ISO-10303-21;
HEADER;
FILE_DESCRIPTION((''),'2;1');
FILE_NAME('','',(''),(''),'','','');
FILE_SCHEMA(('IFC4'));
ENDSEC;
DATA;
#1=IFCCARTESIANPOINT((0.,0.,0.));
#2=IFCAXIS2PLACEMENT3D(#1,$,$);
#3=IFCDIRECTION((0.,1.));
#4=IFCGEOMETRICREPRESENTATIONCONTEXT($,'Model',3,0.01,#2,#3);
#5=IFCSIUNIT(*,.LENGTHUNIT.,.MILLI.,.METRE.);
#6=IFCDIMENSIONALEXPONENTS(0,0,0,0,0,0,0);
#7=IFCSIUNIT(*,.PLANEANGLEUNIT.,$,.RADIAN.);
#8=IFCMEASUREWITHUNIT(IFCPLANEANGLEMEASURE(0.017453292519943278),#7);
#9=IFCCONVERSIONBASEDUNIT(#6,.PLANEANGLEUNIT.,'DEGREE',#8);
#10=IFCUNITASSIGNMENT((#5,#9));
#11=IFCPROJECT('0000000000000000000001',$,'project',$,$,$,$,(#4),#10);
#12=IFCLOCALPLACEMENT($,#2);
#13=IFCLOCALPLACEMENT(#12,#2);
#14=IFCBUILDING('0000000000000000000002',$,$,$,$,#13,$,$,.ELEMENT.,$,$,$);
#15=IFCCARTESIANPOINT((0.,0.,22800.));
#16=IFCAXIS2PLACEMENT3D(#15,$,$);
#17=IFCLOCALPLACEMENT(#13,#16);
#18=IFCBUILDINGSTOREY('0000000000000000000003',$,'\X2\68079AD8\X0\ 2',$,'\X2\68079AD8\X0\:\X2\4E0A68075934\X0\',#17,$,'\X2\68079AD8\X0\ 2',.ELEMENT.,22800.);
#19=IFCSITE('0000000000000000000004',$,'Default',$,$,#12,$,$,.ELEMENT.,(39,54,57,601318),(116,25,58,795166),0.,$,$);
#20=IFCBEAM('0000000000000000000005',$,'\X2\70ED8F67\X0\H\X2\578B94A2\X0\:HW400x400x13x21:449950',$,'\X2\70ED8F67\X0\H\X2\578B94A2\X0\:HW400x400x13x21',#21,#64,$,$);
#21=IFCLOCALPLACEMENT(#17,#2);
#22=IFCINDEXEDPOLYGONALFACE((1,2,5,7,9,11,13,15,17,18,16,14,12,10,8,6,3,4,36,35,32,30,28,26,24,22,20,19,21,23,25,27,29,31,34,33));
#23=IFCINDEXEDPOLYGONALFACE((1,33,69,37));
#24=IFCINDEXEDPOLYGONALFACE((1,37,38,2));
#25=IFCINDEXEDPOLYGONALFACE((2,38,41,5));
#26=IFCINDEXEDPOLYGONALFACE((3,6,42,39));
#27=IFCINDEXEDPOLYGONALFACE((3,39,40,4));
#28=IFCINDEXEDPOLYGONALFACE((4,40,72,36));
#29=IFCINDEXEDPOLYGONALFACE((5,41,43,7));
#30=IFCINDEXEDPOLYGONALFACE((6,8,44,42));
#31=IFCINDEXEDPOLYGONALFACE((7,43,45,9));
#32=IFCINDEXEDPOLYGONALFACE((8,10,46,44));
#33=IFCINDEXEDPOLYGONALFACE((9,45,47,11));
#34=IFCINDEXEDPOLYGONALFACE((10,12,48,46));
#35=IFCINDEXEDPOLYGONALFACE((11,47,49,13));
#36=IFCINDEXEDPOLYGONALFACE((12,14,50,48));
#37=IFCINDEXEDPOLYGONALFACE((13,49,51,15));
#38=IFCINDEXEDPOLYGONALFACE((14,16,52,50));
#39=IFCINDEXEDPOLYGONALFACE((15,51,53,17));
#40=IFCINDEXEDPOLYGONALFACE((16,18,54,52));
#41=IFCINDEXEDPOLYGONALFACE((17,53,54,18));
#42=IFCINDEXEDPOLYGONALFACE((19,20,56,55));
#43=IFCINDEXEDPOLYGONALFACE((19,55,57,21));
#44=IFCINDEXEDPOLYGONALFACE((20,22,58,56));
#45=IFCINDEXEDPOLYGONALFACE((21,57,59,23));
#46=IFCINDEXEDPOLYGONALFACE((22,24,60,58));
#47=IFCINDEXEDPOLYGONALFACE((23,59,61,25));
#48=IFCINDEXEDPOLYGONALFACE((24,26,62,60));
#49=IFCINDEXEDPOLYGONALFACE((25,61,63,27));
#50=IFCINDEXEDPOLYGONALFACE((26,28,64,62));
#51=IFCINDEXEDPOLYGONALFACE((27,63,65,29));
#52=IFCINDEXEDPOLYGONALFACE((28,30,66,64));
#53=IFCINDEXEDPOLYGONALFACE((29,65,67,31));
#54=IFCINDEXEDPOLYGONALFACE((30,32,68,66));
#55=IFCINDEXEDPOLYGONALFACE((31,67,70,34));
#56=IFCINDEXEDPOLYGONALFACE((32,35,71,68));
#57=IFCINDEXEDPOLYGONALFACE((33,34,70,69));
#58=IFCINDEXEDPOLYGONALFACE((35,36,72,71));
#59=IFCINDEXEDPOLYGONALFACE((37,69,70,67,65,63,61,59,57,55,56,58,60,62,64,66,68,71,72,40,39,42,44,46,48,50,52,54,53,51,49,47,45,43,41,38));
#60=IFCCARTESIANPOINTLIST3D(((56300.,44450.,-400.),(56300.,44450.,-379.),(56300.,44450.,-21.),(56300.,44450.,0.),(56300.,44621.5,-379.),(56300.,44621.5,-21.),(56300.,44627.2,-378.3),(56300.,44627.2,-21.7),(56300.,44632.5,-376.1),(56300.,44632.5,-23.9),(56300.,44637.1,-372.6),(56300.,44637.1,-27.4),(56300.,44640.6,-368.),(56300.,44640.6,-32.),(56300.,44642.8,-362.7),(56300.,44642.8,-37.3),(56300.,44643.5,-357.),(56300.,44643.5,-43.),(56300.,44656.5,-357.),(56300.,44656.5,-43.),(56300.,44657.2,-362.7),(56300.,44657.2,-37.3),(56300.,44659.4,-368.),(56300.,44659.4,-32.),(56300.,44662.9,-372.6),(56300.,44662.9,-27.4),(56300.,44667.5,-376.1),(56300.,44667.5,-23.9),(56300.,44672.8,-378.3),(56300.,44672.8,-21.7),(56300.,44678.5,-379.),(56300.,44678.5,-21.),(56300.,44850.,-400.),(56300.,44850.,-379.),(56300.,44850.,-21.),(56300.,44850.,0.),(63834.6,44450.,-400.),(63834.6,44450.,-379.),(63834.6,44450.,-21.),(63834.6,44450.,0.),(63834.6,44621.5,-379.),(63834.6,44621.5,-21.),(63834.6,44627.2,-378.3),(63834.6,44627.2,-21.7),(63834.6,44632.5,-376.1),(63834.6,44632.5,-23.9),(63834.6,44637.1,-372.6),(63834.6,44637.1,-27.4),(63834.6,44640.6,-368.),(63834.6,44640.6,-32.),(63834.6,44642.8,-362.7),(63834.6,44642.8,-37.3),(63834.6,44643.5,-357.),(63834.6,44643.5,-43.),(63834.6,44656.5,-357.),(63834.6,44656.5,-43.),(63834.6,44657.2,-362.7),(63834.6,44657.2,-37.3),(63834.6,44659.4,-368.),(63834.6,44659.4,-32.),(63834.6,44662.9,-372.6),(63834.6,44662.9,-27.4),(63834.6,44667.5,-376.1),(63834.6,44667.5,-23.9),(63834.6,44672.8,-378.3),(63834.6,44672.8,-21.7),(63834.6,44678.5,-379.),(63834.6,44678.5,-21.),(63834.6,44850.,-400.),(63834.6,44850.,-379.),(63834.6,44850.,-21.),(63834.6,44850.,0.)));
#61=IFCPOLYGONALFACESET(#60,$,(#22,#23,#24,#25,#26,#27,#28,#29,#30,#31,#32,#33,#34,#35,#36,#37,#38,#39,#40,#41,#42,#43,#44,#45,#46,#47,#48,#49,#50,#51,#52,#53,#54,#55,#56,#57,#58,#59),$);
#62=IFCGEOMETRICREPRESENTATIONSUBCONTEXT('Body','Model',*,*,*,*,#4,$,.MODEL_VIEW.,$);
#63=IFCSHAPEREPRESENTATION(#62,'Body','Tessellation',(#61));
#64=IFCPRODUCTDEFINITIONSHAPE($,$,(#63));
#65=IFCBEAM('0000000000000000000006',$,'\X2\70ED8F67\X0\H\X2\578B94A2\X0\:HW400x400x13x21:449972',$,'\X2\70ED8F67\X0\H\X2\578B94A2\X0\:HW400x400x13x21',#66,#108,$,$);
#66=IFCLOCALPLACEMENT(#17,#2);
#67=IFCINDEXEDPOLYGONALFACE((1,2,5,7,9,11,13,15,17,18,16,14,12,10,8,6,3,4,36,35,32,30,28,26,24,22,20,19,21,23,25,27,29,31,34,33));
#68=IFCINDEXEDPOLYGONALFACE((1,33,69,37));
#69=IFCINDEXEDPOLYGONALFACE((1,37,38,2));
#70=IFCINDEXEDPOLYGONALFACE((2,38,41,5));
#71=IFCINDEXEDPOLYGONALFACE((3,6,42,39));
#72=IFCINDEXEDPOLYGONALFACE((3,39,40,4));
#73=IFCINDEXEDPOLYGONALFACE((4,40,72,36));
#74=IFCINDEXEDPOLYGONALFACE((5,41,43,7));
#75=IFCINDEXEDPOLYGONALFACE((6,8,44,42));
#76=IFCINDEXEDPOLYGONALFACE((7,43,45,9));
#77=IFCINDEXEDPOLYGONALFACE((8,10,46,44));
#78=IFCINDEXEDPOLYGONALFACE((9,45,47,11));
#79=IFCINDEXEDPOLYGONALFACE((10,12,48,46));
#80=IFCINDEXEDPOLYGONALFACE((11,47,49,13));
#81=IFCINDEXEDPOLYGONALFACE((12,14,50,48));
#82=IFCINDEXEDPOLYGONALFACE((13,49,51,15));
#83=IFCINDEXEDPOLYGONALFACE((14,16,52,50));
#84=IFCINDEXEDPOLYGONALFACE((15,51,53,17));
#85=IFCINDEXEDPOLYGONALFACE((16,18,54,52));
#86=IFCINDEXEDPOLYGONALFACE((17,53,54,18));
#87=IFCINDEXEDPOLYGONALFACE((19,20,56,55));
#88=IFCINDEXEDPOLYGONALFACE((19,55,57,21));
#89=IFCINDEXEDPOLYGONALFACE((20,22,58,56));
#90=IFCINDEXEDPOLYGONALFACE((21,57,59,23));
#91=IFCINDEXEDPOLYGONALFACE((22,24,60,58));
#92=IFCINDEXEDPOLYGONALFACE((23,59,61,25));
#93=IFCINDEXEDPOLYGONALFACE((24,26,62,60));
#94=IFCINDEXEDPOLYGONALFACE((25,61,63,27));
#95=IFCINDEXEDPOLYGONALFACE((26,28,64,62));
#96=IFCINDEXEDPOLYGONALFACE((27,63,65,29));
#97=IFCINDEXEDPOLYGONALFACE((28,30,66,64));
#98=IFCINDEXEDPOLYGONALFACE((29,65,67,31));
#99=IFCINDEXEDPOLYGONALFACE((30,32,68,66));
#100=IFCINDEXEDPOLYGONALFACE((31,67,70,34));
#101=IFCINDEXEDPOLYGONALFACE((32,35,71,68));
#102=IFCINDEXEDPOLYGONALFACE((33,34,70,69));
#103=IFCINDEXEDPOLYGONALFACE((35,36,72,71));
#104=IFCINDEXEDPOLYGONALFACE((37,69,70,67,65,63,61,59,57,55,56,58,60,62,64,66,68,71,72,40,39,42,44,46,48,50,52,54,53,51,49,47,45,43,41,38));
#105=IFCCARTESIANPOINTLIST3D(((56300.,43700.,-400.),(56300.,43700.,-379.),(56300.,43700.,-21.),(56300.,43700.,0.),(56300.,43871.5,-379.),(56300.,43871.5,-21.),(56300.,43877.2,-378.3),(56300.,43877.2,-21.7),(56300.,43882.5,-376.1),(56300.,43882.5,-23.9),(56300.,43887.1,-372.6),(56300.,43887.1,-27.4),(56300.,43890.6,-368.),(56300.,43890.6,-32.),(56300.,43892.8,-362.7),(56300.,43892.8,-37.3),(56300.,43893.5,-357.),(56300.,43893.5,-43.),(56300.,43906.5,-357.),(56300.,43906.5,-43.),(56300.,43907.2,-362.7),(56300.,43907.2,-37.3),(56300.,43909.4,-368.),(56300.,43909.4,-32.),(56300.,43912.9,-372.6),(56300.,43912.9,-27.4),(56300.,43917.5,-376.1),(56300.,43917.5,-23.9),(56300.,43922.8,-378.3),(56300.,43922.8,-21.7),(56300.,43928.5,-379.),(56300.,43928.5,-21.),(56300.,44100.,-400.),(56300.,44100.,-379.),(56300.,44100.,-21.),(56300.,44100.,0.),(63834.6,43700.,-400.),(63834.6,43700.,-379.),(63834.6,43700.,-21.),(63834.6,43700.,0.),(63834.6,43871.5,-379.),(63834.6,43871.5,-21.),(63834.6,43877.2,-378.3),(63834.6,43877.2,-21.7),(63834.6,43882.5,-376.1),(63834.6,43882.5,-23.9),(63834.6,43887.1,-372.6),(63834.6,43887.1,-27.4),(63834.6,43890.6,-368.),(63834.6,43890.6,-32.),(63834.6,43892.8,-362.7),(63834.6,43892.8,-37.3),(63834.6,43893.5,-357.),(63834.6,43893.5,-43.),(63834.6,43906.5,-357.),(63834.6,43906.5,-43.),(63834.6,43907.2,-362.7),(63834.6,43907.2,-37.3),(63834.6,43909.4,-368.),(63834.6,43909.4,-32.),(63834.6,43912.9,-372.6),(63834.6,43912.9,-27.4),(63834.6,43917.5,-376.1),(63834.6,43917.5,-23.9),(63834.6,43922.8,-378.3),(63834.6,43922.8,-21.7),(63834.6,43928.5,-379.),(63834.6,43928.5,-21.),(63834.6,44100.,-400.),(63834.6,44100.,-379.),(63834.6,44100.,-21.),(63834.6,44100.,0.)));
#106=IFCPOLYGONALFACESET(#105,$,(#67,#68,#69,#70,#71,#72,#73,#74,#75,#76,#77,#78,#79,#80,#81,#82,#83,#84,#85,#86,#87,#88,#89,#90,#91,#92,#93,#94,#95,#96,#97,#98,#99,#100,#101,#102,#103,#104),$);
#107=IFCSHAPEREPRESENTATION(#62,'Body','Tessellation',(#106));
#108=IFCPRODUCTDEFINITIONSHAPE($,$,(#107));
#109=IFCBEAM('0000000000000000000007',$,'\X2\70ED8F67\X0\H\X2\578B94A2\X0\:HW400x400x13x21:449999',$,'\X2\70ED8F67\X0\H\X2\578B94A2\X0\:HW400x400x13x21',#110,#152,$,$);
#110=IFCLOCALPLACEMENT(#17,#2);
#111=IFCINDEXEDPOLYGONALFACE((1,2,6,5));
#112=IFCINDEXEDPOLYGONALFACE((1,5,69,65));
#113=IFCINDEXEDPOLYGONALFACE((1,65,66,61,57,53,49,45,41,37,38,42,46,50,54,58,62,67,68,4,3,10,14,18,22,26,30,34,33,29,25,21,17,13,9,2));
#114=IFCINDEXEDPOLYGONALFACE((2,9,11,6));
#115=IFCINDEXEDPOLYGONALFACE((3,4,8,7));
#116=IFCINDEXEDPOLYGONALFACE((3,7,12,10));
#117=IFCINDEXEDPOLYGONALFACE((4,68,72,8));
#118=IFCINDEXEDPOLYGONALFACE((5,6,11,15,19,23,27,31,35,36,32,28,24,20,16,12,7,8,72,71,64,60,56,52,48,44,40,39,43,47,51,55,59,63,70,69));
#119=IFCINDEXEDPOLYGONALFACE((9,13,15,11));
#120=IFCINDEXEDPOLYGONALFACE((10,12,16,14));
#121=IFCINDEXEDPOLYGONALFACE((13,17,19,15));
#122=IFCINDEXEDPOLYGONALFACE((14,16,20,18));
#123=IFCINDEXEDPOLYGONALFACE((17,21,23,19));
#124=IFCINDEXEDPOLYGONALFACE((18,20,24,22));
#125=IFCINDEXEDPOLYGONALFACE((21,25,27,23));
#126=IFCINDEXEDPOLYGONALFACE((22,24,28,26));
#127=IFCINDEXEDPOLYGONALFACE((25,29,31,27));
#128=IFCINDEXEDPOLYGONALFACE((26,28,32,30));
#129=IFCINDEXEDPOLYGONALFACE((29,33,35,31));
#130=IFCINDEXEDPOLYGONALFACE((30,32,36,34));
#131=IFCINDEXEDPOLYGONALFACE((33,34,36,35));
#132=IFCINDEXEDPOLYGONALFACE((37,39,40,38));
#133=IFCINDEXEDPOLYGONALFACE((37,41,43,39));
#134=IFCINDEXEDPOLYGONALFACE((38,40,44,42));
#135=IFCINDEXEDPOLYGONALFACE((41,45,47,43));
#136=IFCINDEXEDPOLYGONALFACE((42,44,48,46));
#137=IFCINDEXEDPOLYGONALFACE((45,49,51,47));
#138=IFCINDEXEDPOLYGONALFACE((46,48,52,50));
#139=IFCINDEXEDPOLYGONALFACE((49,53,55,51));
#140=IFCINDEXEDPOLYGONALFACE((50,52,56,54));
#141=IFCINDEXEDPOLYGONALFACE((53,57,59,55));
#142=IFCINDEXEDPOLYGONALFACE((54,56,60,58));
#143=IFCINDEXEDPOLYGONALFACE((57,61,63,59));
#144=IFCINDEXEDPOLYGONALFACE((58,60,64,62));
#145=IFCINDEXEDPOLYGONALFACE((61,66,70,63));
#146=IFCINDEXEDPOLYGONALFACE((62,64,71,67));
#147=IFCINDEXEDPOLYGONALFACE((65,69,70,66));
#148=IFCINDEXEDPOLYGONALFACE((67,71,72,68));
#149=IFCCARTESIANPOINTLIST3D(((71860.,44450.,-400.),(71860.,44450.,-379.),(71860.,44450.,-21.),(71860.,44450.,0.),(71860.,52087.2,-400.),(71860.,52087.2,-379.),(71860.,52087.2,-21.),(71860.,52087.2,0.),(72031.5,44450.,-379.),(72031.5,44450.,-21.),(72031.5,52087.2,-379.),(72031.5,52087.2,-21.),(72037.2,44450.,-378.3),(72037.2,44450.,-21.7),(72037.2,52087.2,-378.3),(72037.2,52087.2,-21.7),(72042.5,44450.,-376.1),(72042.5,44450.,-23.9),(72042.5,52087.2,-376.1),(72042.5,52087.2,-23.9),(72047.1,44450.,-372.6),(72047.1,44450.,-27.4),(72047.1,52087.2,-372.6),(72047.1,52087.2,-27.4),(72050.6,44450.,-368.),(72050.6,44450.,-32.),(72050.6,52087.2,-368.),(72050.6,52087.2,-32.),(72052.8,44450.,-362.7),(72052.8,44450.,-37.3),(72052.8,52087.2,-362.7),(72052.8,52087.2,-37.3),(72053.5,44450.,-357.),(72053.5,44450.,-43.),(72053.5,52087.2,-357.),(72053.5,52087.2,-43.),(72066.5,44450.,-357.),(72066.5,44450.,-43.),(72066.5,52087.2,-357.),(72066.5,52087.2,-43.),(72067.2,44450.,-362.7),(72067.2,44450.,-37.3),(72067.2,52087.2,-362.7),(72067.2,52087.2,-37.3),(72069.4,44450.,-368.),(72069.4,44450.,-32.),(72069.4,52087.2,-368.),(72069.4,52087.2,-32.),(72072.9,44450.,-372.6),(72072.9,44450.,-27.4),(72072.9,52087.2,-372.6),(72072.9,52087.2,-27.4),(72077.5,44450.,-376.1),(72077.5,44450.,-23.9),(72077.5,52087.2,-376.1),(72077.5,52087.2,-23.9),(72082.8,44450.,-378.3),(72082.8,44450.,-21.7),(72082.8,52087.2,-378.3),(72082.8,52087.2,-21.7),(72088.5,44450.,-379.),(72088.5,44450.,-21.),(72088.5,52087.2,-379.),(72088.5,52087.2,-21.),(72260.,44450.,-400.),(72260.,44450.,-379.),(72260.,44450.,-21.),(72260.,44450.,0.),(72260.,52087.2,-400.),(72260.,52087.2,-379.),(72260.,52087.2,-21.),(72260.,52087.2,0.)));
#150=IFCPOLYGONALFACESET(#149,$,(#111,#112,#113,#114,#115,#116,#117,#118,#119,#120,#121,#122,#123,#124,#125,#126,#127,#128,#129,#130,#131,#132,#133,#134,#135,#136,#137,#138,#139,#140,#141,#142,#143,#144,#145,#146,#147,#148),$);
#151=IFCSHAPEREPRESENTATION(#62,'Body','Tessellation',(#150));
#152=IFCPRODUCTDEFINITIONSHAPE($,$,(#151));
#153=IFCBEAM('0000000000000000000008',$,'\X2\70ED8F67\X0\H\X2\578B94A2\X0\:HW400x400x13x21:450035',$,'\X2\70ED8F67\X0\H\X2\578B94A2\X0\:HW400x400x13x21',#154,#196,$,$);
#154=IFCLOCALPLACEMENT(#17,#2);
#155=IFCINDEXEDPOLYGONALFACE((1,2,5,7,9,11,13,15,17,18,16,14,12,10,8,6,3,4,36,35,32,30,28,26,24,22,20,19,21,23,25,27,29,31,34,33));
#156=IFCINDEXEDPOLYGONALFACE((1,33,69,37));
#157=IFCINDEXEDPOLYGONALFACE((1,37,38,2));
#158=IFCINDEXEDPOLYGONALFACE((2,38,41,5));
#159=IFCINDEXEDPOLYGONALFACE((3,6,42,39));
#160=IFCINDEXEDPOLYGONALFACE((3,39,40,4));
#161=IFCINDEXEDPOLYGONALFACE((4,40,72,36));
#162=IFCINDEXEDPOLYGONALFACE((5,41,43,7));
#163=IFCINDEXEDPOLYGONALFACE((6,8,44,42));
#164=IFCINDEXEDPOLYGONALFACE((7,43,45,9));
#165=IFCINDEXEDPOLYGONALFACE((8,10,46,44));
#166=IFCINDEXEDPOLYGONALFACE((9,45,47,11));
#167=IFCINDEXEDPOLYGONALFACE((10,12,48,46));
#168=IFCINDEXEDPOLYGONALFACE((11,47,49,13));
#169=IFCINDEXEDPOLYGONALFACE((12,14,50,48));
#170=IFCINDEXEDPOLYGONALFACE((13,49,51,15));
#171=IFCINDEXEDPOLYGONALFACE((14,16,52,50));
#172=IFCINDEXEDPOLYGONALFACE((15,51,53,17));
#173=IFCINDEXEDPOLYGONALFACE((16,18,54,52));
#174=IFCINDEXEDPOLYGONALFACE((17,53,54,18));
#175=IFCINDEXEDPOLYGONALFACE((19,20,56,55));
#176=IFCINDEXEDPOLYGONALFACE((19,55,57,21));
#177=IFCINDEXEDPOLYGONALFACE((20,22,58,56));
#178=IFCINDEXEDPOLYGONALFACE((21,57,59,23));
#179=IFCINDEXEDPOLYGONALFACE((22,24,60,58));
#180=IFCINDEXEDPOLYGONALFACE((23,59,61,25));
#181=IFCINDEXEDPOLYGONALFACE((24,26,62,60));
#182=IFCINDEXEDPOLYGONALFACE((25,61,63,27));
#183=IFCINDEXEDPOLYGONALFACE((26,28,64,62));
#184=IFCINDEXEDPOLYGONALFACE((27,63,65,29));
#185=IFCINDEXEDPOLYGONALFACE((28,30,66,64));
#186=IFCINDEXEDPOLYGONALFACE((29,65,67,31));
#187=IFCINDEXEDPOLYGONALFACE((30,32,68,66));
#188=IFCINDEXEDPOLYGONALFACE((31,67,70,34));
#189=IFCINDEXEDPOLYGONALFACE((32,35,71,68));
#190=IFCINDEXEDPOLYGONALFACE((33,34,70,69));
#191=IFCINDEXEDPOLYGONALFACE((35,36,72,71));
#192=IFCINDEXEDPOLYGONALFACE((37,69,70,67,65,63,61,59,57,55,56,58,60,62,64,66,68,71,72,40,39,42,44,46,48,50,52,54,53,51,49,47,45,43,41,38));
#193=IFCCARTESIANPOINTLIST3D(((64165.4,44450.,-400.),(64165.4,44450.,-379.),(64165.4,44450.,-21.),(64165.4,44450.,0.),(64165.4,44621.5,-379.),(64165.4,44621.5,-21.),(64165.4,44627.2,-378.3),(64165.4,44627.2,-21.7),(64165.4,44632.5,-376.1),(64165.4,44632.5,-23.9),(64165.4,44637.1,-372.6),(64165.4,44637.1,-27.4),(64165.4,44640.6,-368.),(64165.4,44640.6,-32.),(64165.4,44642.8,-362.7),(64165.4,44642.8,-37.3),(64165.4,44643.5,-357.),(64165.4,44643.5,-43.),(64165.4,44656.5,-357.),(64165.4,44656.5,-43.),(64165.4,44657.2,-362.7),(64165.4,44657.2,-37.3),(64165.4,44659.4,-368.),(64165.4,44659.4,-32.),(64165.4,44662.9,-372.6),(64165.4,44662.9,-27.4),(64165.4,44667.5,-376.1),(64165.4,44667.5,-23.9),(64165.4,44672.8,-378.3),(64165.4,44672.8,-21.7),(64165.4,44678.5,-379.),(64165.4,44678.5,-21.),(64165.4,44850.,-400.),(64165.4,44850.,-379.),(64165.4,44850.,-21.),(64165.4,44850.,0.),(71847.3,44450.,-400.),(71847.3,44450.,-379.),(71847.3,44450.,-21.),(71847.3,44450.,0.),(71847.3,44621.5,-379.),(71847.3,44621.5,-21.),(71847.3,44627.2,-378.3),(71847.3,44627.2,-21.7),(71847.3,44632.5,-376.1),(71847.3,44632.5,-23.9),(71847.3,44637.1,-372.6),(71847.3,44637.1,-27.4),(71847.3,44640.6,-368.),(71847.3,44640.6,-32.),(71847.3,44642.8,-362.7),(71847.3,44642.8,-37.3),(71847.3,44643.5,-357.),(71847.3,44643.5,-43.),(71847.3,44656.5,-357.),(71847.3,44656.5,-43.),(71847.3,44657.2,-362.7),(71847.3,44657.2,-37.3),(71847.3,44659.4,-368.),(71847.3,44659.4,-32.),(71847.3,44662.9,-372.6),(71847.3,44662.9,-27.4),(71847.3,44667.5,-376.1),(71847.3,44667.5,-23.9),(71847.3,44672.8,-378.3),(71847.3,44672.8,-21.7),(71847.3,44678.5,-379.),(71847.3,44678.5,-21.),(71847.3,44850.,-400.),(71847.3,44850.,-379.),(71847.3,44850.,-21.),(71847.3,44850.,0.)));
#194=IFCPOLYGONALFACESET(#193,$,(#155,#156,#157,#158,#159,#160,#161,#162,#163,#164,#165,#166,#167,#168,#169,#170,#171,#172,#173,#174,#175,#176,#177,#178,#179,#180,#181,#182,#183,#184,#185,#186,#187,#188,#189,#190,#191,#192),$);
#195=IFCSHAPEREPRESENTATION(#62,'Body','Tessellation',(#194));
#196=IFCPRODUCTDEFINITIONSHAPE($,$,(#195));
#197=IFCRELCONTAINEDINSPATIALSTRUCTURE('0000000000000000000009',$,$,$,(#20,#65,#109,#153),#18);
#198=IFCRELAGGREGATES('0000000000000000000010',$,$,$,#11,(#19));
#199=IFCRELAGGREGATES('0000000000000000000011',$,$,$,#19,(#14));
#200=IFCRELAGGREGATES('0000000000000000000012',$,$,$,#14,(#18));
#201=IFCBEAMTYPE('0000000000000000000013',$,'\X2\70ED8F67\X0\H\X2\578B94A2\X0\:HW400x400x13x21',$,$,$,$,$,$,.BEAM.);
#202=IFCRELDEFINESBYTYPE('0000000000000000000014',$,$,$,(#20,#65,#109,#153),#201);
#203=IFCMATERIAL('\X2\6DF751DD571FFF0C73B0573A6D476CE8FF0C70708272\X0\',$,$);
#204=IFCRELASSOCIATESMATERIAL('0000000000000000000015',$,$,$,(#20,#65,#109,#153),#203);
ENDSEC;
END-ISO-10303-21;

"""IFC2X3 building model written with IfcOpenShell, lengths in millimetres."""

from ifc_helpers import new_model, entity, si_unit, converted_unit, direction, frame, frame_2d, origin, place, context, subcontext, project, spatial, i_section, extrude, material, type_object, element, save


model = new_model("IFC2X3")

# Units and contexts
model_context = context("Model", 3, precision=0.01, world=origin(), true_north=direction((0.0, 1.0)))
body_context = subcontext(model_context, "Body", "Model", "MODEL_VIEW")
ifc_project = project(units=[si_unit("LENGTHUNIT", "METRE", prefix="MILLI"), converted_unit("PLANEANGLEUNIT", "DEGREE", entity("IfcPlaneAngleMeasure", 0.017453292519943278), si_unit("PLANEANGLEUNIT", "RADIAN"), dimensions=[0, 0, 0, 0, 0, 0, 0])], contexts=[model_context])

# Site, building, storey
site_placement = place(None, origin())
site = spatial("IfcSite", under=ifc_project, at=site_placement, Name="Default", CompositionType="ELEMENT", RefLatitude=(39, 54, 57, 601318), RefLongitude=(116, 25, 58, 795166), RefElevation=0.0)
building_placement = place(site_placement, origin())
building = spatial("IfcBuilding", under=site, at=building_placement, CompositionType="ELEMENT")
storey_placement = place(building_placement, frame((0.0, 0.0, 22800.0)))
storey = spatial("IfcBuildingStorey", under=building, at=storey_placement, Name="标高 2", ObjectType="标高:上标头", LongName="标高 2", CompositionType="ELEMENT", Elevation=22800.0)

# Beams
ifc_material = material(Name="混凝土，现场浇注，灰色")
beam_type = type_object("IfcBeamType", Name="热轧H型钢:HW400x400x13x21", PredefinedType="BEAM")
beam_1_placement = place(storey_placement, frame((64000.0, 44650.0, 0.0), z_axis=(0.0, 0.0, 1.0), x_axis=(-1.0, 0.0, 0.0)))
element("IfcBeam", 1, at=beam_1_placement, inside=storey, type_object=beam_type, material=ifc_material, Name="热轧H型钢:HW400x400x13x21:449950", ObjectType="热轧H型钢:HW400x400x13x21", context=body_context, shape_type="SweptSolid", body=[
    extrude(i_section(OverallWidth=400.0, OverallDepth=400.0, WebThickness=13.0, FlangeThickness=21.0, FilletRadius=22.0, at=frame_2d((0.0, 0.0), x_axis=(0.0, 1.0))), frame((165.4, 0.0, -200.0), z_axis=(1.0, 0.0, 0.0), x_axis=(0.0, 0.0, -1.0)), (0.0, 0.0, 1.0), 7534.6),
])
beam_2_placement = place(storey_placement, frame((56300.0, 43900.0, 0.0)))
element("IfcBeam", 2, at=beam_2_placement, inside=storey, type_object=beam_type, material=ifc_material, Name="热轧H型钢:HW400x400x13x21:449972", ObjectType="热轧H型钢:HW400x400x13x21", context=body_context, shape_type="SweptSolid", body=[
    extrude(i_section(OverallWidth=400.0, OverallDepth=400.0, WebThickness=13.0, FlangeThickness=21.0, FilletRadius=22.0, at=frame_2d((0.0, 0.0), x_axis=(0.0, 1.0))), frame((0.0, 0.0, -200.0), z_axis=(1.0, 0.0, 0.0), x_axis=(0.0, 0.0, -1.0)), (0.0, 0.0, 1.0), 7534.6),
])
beam_3_placement = place(storey_placement, frame((72060.0, 52100.0, 0.0), z_axis=(0.0, 0.0, 1.0), x_axis=(0.0, -1.0, 0.0)))
element("IfcBeam", 3, at=beam_3_placement, inside=storey, type_object=beam_type, material=ifc_material, Name="热轧H型钢:HW400x400x13x21:449999", ObjectType="热轧H型钢:HW400x400x13x21", context=body_context, shape_type="SweptSolid", body=[
    extrude(i_section(OverallWidth=400.0, OverallDepth=400.0, WebThickness=13.0, FlangeThickness=21.0, FilletRadius=22.0, at=frame_2d((0.0, 0.0), x_axis=(0.0, 1.0))), frame((12.8, 0.0, -200.0), z_axis=(1.0, 0.0, 0.0), x_axis=(0.0, 0.0, -1.0)), (0.0, 0.0, 1.0), 7637.2),
])
beam_4_placement = place(storey_placement, frame((64000.0, 44650.0, 0.0)))
element("IfcBeam", 4, at=beam_4_placement, inside=storey, type_object=beam_type, material=ifc_material, Name="热轧H型钢:HW400x400x13x21:450035", ObjectType="热轧H型钢:HW400x400x13x21", context=body_context, shape_type="SweptSolid", body=[
    extrude(i_section(OverallWidth=400.0, OverallDepth=400.0, WebThickness=13.0, FlangeThickness=21.0, FilletRadius=22.0, at=frame_2d((0.0, 0.0), x_axis=(0.0, 1.0))), frame((165.4, 0.0, -200.0), z_axis=(1.0, 0.0, 0.0), x_axis=(0.0, 0.0, -1.0)), (0.0, 0.0, 1.0), 7681.9),
])

save(model, "model.ifc")
